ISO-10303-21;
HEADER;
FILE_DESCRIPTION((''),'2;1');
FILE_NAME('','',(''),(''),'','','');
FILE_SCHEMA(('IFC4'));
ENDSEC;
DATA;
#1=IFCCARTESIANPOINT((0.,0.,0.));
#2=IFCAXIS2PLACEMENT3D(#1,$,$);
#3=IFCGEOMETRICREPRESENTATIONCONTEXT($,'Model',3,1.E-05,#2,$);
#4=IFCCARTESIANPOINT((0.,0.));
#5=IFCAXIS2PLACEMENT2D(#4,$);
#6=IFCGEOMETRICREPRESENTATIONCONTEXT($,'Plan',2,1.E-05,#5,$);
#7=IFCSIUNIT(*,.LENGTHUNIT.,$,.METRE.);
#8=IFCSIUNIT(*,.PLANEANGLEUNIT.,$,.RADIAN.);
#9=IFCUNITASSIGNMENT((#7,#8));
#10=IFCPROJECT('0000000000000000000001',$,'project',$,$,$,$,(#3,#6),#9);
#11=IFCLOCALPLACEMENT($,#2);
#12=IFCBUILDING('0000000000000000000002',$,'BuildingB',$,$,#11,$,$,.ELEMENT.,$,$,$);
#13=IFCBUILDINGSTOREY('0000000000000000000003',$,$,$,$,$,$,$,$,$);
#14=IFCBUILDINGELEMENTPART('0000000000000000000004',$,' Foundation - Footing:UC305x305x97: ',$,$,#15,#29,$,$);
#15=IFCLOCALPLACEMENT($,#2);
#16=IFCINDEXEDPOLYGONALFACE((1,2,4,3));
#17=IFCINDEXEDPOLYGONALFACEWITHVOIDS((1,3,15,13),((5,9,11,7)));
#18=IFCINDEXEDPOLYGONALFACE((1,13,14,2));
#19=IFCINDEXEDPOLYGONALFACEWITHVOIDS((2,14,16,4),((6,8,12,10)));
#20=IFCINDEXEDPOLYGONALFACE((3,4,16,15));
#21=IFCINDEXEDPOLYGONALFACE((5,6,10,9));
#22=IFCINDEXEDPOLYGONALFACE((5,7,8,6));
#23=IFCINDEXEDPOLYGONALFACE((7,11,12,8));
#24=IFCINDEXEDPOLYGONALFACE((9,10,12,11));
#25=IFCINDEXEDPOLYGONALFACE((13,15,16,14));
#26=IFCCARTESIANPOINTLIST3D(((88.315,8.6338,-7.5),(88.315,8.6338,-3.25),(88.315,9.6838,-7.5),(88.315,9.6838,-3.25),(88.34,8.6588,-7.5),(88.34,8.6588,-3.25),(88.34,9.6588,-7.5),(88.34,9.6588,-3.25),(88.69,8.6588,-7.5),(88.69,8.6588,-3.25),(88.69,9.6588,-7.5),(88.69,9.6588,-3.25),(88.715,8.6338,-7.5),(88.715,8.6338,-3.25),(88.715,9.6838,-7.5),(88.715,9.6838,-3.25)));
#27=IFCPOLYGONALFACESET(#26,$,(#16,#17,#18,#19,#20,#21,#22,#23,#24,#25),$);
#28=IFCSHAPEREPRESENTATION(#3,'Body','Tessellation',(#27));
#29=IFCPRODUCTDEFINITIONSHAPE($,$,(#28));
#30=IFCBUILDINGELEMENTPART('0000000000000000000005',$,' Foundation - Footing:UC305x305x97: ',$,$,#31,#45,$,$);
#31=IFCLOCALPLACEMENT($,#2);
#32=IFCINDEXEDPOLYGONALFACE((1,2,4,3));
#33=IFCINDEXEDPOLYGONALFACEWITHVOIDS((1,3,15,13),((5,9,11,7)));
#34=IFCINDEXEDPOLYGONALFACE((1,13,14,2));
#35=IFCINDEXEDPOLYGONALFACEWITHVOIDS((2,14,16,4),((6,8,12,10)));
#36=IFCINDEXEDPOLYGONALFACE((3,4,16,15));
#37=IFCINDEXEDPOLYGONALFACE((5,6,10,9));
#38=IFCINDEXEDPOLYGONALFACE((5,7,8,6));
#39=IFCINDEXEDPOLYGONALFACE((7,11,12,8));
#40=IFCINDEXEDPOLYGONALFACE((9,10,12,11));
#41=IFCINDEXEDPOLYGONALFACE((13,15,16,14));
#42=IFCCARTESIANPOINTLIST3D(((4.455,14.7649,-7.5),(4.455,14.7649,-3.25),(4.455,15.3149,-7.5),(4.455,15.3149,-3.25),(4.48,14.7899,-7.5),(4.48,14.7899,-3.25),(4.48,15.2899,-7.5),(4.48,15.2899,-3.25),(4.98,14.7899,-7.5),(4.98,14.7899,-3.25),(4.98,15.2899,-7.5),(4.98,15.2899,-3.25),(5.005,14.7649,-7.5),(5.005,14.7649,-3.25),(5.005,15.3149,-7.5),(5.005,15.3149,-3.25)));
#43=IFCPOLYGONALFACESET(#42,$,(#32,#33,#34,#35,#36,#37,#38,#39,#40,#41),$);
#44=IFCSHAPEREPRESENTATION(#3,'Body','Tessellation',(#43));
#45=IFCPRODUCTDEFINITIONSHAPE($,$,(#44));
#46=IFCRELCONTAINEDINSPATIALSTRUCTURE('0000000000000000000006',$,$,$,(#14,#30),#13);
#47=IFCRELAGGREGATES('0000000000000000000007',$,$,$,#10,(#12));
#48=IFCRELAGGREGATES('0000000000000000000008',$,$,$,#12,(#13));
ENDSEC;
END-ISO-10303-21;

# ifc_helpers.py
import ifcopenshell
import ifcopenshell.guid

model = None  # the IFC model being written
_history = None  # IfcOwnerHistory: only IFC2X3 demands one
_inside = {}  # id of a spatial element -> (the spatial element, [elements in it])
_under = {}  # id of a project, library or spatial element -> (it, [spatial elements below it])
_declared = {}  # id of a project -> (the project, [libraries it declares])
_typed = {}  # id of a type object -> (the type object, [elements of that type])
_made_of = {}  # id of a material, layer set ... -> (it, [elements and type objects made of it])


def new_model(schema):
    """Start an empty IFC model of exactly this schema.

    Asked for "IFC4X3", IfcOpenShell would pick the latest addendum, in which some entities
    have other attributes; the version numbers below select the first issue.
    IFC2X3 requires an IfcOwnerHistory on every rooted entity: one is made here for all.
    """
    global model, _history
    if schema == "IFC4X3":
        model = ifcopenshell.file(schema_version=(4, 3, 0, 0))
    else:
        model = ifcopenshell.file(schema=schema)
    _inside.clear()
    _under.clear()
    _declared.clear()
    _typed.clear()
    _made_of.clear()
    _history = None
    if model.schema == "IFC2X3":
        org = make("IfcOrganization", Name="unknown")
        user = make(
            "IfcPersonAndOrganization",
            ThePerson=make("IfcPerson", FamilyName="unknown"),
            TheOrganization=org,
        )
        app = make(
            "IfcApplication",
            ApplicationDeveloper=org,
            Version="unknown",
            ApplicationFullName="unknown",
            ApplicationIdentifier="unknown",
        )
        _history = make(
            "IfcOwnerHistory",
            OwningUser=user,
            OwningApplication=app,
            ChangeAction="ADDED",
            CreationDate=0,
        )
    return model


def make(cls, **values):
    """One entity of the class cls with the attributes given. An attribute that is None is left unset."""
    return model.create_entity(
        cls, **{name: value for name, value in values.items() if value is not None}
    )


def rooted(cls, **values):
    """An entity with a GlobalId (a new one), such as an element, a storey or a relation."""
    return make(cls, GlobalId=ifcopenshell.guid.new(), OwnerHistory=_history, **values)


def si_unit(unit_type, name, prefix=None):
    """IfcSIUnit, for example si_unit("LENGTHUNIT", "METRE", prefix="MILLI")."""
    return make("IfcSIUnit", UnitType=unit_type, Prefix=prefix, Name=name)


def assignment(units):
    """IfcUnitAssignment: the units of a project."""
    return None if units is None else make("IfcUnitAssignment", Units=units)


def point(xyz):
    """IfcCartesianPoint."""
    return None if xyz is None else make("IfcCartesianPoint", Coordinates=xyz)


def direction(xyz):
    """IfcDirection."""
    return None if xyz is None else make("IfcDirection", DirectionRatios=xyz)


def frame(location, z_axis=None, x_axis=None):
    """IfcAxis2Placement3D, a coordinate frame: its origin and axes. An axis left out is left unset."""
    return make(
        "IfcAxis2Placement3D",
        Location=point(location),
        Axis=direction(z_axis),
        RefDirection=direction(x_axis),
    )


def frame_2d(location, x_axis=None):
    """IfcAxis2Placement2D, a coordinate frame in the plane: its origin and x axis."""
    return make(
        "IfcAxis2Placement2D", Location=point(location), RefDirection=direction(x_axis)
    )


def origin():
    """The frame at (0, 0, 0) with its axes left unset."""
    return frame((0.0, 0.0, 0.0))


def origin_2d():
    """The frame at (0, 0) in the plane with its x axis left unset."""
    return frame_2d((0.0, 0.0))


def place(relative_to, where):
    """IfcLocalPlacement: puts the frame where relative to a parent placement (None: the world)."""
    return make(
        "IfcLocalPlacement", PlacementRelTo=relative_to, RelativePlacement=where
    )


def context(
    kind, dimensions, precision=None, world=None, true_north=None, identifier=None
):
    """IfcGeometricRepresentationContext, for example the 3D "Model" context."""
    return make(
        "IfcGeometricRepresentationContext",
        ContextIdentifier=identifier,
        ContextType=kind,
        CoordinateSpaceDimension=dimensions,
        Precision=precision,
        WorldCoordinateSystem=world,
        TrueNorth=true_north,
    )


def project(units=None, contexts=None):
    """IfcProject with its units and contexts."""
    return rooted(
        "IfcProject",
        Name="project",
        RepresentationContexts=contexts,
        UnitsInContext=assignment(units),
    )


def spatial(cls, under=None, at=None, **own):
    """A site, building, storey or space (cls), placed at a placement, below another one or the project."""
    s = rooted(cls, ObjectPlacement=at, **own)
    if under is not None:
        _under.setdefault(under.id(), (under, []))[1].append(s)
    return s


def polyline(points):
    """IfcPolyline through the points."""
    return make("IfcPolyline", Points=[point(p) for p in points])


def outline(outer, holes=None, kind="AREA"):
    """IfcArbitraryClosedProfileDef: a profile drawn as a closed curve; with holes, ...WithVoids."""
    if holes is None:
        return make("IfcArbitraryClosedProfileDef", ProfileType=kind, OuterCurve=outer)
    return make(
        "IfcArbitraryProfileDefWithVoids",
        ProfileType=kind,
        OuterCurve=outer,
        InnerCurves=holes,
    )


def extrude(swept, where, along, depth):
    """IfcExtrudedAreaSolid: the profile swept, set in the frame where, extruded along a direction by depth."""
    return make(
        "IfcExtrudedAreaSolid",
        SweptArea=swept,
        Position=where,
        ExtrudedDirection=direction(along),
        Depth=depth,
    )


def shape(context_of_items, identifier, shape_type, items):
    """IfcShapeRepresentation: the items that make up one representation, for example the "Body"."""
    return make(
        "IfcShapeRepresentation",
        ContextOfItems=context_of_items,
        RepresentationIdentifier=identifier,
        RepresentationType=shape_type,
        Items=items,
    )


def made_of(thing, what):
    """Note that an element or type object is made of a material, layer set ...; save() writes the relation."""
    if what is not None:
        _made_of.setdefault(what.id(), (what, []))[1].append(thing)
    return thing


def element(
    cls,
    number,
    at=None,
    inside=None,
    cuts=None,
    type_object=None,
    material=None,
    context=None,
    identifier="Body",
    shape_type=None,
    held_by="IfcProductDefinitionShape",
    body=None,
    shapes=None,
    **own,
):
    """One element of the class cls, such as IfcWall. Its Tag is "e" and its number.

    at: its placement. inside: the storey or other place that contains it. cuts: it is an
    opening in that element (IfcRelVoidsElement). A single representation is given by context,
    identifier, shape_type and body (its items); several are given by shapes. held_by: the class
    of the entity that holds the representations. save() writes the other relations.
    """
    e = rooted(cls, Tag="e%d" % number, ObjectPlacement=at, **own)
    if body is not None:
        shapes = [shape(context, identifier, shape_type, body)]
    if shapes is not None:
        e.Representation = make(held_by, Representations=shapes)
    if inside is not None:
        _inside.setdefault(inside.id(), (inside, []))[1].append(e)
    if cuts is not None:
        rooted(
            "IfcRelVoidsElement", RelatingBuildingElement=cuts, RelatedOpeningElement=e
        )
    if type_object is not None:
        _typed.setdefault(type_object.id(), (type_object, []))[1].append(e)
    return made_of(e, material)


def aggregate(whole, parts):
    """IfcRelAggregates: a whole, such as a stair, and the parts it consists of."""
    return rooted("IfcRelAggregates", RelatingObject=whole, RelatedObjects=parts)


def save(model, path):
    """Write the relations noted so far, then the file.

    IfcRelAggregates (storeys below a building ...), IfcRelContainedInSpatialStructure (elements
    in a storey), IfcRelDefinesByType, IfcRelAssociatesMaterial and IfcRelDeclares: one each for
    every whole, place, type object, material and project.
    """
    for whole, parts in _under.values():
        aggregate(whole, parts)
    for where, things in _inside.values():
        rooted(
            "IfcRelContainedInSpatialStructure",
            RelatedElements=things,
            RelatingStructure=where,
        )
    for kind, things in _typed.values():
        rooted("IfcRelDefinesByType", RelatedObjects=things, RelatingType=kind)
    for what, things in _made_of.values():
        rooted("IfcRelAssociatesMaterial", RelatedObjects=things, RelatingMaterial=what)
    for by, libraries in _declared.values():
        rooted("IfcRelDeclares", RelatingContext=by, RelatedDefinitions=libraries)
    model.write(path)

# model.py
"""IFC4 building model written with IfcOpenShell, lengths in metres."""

from ifc_helpers import new_model, si_unit, origin, origin_2d, place, context, project, spatial, polyline, outline, extrude, element, save


model = new_model("IFC4")

# Units and contexts
model_context = context("Model", 3, precision=1e-05, world=origin())
plan_context = context("Plan", 2, precision=1e-05, world=origin_2d())
ifc_project = project(units=[si_unit("LENGTHUNIT", "METRE"), si_unit("PLANEANGLEUNIT", "RADIAN")], contexts=[model_context, plan_context])

# Building, storey
building_placement = place(None, origin())
building = spatial("IfcBuilding", under=ifc_project, at=building_placement, Name="BuildingB", CompositionType="ELEMENT")
storey = spatial("IfcBuildingStorey", under=building)

# Building element parts, openings
building_element_part_1 = element("IfcBuildingElementPart", 1, inside=storey, Name=" Foundation - Footing:UC305x305x97: ", context=model_context, shape_type="SweptSolid", body=[
    extrude(outline(polyline([(88.315, 8.6338, -7.5), (88.715, 8.6338, -7.5), (88.715, 9.6838, -7.5), (88.315, 9.6838, -7.5), (88.315, 8.6338, -7.5)])), None, (0.0, 0.0, 1.0), 4.25),
])
element("IfcOpeningElement", 2, inside=storey, cuts=building_element_part_1, context=model_context, shape_type="SweptSolid", body=[
    extrude(outline(polyline([(88.34, 8.6588, -7.5), (88.69, 8.6588, -7.5), (88.69, 9.6588, -7.5), (88.34, 9.6588, -7.5), (88.34, 8.6588, -7.5)])), None, (0.0, 0.0, 1.0), 4.25),
])
building_element_part_2 = element("IfcBuildingElementPart", 3, inside=storey, Name=" Foundation - Footing:UC305x305x97: ", context=model_context, shape_type="SweptSolid", body=[
    extrude(outline(polyline([(5.005, 15.3149, -7.5), (4.455, 15.3149, -7.5), (4.455, 14.7649, -7.5), (5.005, 14.7649, -7.5), (5.005, 15.3149, -7.5)])), None, (0.0, 0.0, 1.0), 4.25),
])
element("IfcOpeningElement", 4, inside=storey, cuts=building_element_part_2, context=model_context, shape_type="SweptSolid", body=[
    extrude(outline(polyline([(4.98, 15.2899, -7.5), (4.48, 15.2899, -7.5), (4.48, 14.7899, -7.5), (4.98, 14.7899, -7.5), (4.98, 15.2899, -7.5)])), None, (0.0, 0.0, 1.0), 4.25),
])

save(model, "model.ifc")
